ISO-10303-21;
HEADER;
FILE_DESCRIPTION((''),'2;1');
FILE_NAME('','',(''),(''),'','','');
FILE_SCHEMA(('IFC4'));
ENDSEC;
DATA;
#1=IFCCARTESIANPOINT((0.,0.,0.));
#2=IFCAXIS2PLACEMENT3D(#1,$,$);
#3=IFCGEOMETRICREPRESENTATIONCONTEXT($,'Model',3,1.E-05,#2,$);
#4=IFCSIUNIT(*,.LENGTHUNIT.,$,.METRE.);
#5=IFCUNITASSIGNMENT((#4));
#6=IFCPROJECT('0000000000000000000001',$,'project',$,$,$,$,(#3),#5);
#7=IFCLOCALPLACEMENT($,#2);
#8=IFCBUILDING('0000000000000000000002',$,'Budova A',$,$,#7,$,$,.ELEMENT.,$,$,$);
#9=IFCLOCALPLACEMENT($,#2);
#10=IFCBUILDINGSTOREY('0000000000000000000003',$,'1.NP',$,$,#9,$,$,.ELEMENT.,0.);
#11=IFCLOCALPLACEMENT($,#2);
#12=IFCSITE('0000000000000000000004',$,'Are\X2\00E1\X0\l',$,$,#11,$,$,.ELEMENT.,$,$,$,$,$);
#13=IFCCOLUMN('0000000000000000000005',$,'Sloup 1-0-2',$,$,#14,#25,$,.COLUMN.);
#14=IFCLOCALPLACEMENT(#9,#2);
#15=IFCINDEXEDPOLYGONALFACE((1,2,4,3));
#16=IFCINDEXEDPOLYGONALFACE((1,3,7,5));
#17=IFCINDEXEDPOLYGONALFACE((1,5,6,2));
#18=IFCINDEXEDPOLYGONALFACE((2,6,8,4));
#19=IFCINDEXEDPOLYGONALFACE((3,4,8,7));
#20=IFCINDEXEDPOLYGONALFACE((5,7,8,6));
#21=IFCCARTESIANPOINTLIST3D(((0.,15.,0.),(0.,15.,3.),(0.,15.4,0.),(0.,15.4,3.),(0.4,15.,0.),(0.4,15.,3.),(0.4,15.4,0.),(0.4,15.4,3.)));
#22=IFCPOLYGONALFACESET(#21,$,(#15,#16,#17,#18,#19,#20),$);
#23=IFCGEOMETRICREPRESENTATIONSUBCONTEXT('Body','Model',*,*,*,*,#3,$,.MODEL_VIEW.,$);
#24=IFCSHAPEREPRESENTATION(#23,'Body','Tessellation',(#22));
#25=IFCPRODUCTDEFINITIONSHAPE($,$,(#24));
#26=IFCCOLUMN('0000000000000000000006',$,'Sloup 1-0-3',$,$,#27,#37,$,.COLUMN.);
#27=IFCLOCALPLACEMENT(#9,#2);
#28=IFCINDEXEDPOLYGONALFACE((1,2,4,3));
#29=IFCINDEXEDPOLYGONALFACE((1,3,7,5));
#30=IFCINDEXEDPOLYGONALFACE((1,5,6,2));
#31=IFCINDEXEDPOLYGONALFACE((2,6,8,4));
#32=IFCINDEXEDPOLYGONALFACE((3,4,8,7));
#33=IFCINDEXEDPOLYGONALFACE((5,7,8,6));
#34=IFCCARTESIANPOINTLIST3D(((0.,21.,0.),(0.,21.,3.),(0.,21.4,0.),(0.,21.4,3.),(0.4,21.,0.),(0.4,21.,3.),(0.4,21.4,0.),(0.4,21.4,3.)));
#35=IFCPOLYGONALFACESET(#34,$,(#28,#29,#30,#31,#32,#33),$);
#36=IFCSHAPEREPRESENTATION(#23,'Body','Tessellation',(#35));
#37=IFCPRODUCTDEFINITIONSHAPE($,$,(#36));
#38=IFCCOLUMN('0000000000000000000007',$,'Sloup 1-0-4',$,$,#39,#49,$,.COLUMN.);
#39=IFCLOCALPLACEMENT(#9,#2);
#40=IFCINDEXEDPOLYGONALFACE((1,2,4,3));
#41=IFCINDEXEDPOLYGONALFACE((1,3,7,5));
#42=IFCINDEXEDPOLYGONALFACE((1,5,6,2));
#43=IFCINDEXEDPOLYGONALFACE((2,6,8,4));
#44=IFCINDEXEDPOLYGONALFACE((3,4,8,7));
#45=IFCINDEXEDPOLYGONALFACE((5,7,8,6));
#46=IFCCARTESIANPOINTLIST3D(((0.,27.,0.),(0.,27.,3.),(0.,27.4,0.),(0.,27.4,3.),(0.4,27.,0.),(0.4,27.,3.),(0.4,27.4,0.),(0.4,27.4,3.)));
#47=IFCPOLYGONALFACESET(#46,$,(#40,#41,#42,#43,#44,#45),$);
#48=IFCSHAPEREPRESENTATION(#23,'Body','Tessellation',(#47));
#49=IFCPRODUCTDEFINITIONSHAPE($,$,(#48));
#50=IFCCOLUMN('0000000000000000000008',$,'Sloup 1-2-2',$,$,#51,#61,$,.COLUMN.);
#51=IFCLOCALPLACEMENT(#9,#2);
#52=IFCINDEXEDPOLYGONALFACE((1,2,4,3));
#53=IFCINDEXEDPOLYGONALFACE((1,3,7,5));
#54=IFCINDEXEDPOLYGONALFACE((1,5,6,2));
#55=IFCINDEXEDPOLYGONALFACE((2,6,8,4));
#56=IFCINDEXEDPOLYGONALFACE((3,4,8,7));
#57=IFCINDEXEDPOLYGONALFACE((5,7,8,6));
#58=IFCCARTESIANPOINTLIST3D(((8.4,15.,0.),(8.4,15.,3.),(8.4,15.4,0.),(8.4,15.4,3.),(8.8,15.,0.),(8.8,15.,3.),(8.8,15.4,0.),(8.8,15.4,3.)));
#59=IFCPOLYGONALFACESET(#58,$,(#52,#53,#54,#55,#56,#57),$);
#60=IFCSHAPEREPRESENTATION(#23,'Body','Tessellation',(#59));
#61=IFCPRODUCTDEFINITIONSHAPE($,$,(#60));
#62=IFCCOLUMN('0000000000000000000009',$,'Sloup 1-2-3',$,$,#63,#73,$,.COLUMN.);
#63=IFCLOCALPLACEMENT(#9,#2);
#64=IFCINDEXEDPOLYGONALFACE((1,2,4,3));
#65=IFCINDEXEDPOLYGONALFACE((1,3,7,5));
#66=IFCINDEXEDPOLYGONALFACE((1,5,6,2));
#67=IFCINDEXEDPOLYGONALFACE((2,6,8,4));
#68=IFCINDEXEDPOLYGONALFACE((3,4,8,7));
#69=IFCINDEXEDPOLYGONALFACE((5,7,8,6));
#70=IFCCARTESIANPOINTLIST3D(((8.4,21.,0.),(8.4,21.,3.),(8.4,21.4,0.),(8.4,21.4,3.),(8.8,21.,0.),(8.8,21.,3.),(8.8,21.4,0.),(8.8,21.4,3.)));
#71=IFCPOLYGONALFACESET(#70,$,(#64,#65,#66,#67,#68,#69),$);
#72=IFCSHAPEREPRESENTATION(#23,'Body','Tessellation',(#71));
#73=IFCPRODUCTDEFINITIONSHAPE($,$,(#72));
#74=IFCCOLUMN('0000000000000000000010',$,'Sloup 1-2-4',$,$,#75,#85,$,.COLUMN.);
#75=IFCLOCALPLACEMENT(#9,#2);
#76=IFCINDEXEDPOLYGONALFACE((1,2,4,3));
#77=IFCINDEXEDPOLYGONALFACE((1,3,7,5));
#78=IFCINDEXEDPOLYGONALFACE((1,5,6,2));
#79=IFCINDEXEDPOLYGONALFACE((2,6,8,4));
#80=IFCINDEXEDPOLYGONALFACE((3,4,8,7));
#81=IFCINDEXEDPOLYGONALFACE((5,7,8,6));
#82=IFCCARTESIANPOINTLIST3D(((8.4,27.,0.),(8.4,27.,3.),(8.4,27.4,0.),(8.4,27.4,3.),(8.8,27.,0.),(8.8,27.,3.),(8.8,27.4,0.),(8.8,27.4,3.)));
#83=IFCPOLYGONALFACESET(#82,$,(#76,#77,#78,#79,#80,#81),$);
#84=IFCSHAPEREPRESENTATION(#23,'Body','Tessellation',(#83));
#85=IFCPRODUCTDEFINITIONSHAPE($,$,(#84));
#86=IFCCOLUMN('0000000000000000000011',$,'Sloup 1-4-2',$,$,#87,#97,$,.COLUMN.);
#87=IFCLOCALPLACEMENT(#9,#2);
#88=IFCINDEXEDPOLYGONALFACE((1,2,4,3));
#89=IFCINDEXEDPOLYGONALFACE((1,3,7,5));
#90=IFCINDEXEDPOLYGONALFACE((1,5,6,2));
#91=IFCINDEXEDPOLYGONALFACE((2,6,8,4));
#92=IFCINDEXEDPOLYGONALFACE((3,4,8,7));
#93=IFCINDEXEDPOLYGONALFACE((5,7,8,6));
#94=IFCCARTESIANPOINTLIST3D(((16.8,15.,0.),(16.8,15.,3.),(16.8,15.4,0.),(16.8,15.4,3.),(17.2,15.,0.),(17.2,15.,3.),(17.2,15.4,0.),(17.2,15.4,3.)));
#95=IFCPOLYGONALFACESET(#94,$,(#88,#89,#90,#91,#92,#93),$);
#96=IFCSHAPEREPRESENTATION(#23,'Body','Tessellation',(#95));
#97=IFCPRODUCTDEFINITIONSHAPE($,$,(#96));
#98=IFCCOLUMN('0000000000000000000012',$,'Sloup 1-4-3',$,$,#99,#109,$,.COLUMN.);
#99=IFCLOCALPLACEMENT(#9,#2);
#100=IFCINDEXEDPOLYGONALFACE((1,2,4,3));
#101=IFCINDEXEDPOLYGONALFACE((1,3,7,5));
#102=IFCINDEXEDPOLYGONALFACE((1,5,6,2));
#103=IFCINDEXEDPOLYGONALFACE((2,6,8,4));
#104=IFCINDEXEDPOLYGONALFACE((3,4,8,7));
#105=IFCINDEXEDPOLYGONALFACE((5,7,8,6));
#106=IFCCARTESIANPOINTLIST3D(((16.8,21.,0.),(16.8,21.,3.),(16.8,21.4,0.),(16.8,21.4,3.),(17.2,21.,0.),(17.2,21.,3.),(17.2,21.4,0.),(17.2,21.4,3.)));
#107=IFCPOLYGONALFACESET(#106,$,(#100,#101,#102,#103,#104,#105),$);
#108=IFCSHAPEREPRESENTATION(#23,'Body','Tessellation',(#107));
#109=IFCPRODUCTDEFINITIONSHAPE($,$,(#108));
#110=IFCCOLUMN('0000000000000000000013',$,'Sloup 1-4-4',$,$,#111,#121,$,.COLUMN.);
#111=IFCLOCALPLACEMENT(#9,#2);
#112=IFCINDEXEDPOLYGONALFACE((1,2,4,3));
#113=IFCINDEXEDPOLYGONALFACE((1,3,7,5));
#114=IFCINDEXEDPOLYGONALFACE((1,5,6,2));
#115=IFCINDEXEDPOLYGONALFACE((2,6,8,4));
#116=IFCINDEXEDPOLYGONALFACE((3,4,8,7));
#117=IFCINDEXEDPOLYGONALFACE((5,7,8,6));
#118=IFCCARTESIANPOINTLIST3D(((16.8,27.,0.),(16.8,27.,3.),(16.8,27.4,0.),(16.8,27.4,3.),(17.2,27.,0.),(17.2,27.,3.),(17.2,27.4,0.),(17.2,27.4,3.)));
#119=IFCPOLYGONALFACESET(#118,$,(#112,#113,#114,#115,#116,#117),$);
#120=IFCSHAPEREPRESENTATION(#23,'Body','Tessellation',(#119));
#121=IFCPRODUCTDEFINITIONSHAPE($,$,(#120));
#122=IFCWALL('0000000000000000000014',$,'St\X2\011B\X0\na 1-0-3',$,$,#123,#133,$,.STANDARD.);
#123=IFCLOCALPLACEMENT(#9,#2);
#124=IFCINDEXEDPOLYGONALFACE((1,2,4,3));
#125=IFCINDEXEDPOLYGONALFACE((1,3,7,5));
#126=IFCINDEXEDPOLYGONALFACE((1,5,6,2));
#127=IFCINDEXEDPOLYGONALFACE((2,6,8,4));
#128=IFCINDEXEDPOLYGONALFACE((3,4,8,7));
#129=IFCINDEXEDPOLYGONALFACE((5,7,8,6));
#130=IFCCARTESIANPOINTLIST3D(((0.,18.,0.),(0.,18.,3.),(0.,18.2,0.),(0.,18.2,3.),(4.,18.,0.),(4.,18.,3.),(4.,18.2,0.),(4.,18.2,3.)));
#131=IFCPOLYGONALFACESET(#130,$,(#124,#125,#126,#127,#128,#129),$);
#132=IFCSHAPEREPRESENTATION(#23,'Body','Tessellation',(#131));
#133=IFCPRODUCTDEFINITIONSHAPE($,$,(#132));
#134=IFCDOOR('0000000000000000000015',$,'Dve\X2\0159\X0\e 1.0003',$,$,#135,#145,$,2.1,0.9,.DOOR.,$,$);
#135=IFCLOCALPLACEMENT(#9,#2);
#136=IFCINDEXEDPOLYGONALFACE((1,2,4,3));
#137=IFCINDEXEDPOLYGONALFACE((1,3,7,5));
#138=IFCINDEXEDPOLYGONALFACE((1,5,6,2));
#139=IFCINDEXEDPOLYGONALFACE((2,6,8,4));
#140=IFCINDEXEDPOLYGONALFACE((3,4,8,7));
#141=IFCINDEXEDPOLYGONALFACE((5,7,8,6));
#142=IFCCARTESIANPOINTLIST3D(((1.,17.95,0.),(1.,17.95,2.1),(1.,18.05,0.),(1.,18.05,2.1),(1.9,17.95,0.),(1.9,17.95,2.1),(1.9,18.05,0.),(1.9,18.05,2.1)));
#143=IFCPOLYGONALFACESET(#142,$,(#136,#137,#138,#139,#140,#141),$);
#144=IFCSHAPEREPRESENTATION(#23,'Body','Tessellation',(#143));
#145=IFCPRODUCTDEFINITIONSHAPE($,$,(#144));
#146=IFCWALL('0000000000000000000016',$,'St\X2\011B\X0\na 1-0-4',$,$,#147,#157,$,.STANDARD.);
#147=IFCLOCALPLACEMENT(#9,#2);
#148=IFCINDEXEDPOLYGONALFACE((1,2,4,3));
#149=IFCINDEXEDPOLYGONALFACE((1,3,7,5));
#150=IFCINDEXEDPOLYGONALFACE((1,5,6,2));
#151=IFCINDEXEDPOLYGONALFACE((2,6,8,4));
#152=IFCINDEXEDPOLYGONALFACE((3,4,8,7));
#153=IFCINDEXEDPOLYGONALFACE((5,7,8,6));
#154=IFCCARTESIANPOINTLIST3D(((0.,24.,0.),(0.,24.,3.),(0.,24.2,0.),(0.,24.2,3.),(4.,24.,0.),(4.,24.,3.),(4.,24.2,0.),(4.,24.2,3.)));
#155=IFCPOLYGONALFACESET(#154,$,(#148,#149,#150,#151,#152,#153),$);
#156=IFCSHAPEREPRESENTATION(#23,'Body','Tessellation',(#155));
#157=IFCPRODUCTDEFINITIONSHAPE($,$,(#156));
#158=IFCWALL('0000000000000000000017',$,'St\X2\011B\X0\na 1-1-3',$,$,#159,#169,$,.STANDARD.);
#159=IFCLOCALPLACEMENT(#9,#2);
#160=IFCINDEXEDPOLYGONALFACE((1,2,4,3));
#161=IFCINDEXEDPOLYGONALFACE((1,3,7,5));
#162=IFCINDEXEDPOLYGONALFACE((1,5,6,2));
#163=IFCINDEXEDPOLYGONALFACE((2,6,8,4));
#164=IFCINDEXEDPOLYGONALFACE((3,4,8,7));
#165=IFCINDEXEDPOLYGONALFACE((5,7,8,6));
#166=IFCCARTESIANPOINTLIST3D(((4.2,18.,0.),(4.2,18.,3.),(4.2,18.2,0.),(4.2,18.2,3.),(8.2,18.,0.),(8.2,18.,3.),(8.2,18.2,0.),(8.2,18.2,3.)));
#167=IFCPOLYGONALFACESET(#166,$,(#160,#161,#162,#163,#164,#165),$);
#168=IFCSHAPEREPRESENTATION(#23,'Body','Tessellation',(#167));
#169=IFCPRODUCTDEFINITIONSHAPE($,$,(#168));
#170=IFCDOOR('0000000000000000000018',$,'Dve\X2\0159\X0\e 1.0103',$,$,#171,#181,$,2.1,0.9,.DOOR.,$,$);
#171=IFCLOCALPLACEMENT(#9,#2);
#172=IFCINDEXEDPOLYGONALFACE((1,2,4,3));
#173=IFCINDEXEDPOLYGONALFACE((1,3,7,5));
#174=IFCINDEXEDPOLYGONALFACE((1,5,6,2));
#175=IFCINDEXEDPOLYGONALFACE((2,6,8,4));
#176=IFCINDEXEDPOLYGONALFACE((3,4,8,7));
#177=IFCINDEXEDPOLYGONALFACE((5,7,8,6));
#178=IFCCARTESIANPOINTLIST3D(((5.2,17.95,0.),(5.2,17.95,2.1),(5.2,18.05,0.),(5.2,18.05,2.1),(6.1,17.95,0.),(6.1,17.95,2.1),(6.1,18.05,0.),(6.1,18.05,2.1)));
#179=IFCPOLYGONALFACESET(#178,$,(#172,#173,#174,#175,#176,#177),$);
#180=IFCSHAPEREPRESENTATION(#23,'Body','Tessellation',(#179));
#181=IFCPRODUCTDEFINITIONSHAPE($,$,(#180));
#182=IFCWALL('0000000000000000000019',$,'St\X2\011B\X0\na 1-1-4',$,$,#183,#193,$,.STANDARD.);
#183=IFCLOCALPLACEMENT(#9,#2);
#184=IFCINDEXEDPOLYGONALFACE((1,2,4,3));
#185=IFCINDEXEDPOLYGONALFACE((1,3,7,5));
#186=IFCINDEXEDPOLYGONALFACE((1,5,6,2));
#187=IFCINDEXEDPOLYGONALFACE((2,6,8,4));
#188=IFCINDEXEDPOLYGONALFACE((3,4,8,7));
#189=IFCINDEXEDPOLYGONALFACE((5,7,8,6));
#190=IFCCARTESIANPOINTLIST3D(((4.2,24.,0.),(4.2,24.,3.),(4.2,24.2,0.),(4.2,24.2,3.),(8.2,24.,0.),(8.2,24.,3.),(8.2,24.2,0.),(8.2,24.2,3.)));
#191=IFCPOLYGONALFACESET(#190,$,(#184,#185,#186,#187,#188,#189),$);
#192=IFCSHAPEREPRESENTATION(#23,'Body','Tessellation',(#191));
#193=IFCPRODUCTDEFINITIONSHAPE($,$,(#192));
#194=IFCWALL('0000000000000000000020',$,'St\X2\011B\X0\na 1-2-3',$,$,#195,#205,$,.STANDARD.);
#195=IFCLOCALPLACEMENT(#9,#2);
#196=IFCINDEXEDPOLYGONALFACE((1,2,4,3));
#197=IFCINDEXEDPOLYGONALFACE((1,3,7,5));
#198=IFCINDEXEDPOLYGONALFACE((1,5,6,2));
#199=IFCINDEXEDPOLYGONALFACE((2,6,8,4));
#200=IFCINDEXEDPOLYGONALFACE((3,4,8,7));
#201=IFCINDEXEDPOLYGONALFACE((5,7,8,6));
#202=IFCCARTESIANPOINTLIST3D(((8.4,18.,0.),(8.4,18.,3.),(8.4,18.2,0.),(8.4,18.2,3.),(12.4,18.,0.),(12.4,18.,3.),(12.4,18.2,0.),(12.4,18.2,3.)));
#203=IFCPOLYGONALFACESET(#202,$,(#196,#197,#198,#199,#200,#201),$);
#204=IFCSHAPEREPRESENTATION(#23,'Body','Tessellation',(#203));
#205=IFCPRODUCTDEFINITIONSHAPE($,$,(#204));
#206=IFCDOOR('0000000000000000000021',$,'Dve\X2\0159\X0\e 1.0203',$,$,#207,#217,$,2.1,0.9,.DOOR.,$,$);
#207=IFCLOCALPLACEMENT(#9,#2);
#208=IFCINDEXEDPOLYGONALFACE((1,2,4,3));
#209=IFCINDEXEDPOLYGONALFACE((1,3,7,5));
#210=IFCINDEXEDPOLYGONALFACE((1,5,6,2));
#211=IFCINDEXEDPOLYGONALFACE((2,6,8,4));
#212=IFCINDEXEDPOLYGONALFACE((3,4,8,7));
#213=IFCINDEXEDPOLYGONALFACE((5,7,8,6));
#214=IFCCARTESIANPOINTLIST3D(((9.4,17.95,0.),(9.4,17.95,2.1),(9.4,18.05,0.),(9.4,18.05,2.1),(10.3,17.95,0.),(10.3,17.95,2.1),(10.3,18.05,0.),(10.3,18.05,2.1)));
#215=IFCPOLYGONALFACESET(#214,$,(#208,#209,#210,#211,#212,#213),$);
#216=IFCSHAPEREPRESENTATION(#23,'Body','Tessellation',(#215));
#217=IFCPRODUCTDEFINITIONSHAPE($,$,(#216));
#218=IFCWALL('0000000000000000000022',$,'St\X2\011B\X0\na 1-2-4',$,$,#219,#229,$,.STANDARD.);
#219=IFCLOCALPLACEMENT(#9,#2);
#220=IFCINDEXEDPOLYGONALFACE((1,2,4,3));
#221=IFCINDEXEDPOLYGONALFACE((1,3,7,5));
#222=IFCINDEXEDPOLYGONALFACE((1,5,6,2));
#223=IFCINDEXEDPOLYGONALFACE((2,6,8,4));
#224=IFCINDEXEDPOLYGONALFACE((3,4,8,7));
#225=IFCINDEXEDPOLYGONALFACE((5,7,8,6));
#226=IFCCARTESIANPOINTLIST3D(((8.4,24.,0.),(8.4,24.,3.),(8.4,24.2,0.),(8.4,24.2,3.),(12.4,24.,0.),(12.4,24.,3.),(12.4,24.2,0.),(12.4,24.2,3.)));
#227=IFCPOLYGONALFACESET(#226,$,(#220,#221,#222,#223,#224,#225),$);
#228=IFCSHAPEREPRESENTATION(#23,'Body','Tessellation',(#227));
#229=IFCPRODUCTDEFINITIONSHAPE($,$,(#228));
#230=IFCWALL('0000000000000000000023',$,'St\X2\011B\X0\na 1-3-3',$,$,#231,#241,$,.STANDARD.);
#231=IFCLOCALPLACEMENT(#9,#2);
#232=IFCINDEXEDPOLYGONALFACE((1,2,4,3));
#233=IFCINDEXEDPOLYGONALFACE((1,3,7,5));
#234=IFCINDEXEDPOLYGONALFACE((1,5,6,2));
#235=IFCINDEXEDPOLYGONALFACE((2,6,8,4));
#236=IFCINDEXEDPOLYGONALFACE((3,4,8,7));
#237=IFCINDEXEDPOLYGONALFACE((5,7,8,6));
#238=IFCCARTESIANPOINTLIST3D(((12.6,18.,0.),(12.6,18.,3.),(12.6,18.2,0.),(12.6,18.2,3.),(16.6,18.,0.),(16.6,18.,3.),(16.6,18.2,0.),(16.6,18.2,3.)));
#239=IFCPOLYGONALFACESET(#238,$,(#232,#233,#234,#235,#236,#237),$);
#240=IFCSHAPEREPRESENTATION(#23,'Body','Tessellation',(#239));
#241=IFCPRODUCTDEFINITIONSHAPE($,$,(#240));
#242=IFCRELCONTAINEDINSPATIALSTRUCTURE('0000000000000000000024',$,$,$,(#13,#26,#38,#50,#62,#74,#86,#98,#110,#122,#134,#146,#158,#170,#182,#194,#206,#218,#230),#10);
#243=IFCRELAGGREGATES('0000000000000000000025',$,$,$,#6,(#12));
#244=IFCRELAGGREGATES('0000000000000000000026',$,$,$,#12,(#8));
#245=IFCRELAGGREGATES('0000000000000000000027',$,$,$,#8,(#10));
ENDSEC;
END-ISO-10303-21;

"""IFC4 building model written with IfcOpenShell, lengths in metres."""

from ifc_helpers import new_model, si_unit, frame, frame_2d, origin, place, context, subcontext, project, spatial, rectangle, extrude, element, save


model = new_model("IFC4")

# Units and contexts
model_context = context("Model", 3, precision=1e-05, world=origin())
body_context = subcontext(model_context, "Body", "Model", "MODEL_VIEW")
ifc_project = project(units=[si_unit("LENGTHUNIT", "METRE")], contexts=[model_context])

# Site, building, storey
site_placement = place(None, origin())
site = spatial("IfcSite", under=ifc_project, at=site_placement, Name="Areál", CompositionType="ELEMENT")
building_placement = place(None, origin())
building = spatial("IfcBuilding", under=site, at=building_placement, Name="Budova A", CompositionType="ELEMENT")
storey_placement = place(None, origin())
storey = spatial("IfcBuildingStorey", under=building, at=storey_placement, Name="1.NP", CompositionType="ELEMENT", Elevation=0.0)

# Columns
for number, where, name in (
    (1, (0.0, 15.0, 0.0), "Sloup 1-0-2"),
    (2, (0.0, 21.0, 0.0), "Sloup 1-0-3"),
    (3, (0.0, 27.0, 0.0), "Sloup 1-0-4"),
    (4, (8.4, 15.0, 0.0), "Sloup 1-2-2"),
    (5, (8.4, 21.0, 0.0), "Sloup 1-2-3"),
    (6, (8.4, 27.0, 0.0), "Sloup 1-2-4"),
    (7, (16.8, 15.0, 0.0), "Sloup 1-4-2"),
    (8, (16.8, 21.0, 0.0), "Sloup 1-4-3"),
    (9, (16.8, 27.0, 0.0), "Sloup 1-4-4"),
):
    element("IfcColumn", number, at=place(storey_placement, frame(where)), inside=storey, Name=name, PredefinedType="COLUMN", context=body_context, shape_type="SweptSolid", body=[
        extrude(rectangle(XDim=0.4, YDim=0.4, at=frame_2d((0.2, 0.2))), origin(), (0.0, 0.0, 1.0), 3.0),
    ])

# Wall
wall_1_placement = place(storey_placement, frame((0.0, 18.0, 0.0)))
element("IfcWall", 10, at=wall_1_placement, inside=storey, Name="Stěna 1-0-3", PredefinedType="STANDARD", context=body_context, shape_type="SweptSolid", body=[
    extrude(rectangle(XDim=4.0, YDim=0.2, at=frame_2d((2.0, 0.1))), origin(), (0.0, 0.0, 1.0), 3.0),
])

# Door
door_1_placement = place(storey_placement, frame((1.0, 17.95, 0.0)))
element("IfcDoor", 11, at=door_1_placement, inside=storey, Name="Dveře 1.0003", OverallHeight=2.1, OverallWidth=0.9, PredefinedType="DOOR", context=body_context, shape_type="SweptSolid", body=[
    extrude(rectangle(XDim=0.9, YDim=0.1, at=frame_2d((0.45, 0.05))), origin(), (0.0, 0.0, 1.0), 2.1),
])

# Walls
for number, where, name in (
    (12, (0.0, 24.0, 0.0), "Stěna 1-0-4"),
    (13, (4.2, 18.0, 0.0), "Stěna 1-1-3"),
):
    element("IfcWall", number, at=place(storey_placement, frame(where)), inside=storey, Name=name, PredefinedType="STANDARD", context=body_context, shape_type="SweptSolid", body=[
        extrude(rectangle(XDim=4.0, YDim=0.2, at=frame_2d((2.0, 0.1))), origin(), (0.0, 0.0, 1.0), 3.0),
    ])

# Door
door_2_placement = place(storey_placement, frame((5.2, 17.95, 0.0)))
element("IfcDoor", 14, at=door_2_placement, inside=storey, Name="Dveře 1.0103", OverallHeight=2.1, OverallWidth=0.9, PredefinedType="DOOR", context=body_context, shape_type="SweptSolid", body=[
    extrude(rectangle(XDim=0.9, YDim=0.1, at=frame_2d((0.45, 0.05))), origin(), (0.0, 0.0, 1.0), 2.1),
])

# Walls
for number, where, name in (
    (15, (4.2, 24.0, 0.0), "Stěna 1-1-4"),
    (16, (8.4, 18.0, 0.0), "Stěna 1-2-3"),
):
    element("IfcWall", number, at=place(storey_placement, frame(where)), inside=storey, Name=name, PredefinedType="STANDARD", context=body_context, shape_type="SweptSolid", body=[
        extrude(rectangle(XDim=4.0, YDim=0.2, at=frame_2d((2.0, 0.1))), origin(), (0.0, 0.0, 1.0), 3.0),
    ])

# Door
door_3_placement = place(storey_placement, frame((9.4, 17.95, 0.0)))
element("IfcDoor", 17, at=door_3_placement, inside=storey, Name="Dveře 1.0203", OverallHeight=2.1, OverallWidth=0.9, PredefinedType="DOOR", context=body_context, shape_type="SweptSolid", body=[
    extrude(rectangle(XDim=0.9, YDim=0.1, at=frame_2d((0.45, 0.05))), origin(), (0.0, 0.0, 1.0), 2.1),
])

# Walls
for number, where, name in (
    (18, (8.4, 24.0, 0.0), "Stěna 1-2-4"),
    (19, (12.6, 18.0, 0.0), "Stěna 1-3-3"),
):
    element("IfcWall", number, at=place(storey_placement, frame(where)), inside=storey, Name=name, PredefinedType="STANDARD", context=body_context, shape_type="SweptSolid", body=[
        extrude(rectangle(XDim=4.0, YDim=0.2, at=frame_2d((2.0, 0.1))), origin(), (0.0, 0.0, 1.0), 3.0),
    ])

save(model, "model.ifc")
